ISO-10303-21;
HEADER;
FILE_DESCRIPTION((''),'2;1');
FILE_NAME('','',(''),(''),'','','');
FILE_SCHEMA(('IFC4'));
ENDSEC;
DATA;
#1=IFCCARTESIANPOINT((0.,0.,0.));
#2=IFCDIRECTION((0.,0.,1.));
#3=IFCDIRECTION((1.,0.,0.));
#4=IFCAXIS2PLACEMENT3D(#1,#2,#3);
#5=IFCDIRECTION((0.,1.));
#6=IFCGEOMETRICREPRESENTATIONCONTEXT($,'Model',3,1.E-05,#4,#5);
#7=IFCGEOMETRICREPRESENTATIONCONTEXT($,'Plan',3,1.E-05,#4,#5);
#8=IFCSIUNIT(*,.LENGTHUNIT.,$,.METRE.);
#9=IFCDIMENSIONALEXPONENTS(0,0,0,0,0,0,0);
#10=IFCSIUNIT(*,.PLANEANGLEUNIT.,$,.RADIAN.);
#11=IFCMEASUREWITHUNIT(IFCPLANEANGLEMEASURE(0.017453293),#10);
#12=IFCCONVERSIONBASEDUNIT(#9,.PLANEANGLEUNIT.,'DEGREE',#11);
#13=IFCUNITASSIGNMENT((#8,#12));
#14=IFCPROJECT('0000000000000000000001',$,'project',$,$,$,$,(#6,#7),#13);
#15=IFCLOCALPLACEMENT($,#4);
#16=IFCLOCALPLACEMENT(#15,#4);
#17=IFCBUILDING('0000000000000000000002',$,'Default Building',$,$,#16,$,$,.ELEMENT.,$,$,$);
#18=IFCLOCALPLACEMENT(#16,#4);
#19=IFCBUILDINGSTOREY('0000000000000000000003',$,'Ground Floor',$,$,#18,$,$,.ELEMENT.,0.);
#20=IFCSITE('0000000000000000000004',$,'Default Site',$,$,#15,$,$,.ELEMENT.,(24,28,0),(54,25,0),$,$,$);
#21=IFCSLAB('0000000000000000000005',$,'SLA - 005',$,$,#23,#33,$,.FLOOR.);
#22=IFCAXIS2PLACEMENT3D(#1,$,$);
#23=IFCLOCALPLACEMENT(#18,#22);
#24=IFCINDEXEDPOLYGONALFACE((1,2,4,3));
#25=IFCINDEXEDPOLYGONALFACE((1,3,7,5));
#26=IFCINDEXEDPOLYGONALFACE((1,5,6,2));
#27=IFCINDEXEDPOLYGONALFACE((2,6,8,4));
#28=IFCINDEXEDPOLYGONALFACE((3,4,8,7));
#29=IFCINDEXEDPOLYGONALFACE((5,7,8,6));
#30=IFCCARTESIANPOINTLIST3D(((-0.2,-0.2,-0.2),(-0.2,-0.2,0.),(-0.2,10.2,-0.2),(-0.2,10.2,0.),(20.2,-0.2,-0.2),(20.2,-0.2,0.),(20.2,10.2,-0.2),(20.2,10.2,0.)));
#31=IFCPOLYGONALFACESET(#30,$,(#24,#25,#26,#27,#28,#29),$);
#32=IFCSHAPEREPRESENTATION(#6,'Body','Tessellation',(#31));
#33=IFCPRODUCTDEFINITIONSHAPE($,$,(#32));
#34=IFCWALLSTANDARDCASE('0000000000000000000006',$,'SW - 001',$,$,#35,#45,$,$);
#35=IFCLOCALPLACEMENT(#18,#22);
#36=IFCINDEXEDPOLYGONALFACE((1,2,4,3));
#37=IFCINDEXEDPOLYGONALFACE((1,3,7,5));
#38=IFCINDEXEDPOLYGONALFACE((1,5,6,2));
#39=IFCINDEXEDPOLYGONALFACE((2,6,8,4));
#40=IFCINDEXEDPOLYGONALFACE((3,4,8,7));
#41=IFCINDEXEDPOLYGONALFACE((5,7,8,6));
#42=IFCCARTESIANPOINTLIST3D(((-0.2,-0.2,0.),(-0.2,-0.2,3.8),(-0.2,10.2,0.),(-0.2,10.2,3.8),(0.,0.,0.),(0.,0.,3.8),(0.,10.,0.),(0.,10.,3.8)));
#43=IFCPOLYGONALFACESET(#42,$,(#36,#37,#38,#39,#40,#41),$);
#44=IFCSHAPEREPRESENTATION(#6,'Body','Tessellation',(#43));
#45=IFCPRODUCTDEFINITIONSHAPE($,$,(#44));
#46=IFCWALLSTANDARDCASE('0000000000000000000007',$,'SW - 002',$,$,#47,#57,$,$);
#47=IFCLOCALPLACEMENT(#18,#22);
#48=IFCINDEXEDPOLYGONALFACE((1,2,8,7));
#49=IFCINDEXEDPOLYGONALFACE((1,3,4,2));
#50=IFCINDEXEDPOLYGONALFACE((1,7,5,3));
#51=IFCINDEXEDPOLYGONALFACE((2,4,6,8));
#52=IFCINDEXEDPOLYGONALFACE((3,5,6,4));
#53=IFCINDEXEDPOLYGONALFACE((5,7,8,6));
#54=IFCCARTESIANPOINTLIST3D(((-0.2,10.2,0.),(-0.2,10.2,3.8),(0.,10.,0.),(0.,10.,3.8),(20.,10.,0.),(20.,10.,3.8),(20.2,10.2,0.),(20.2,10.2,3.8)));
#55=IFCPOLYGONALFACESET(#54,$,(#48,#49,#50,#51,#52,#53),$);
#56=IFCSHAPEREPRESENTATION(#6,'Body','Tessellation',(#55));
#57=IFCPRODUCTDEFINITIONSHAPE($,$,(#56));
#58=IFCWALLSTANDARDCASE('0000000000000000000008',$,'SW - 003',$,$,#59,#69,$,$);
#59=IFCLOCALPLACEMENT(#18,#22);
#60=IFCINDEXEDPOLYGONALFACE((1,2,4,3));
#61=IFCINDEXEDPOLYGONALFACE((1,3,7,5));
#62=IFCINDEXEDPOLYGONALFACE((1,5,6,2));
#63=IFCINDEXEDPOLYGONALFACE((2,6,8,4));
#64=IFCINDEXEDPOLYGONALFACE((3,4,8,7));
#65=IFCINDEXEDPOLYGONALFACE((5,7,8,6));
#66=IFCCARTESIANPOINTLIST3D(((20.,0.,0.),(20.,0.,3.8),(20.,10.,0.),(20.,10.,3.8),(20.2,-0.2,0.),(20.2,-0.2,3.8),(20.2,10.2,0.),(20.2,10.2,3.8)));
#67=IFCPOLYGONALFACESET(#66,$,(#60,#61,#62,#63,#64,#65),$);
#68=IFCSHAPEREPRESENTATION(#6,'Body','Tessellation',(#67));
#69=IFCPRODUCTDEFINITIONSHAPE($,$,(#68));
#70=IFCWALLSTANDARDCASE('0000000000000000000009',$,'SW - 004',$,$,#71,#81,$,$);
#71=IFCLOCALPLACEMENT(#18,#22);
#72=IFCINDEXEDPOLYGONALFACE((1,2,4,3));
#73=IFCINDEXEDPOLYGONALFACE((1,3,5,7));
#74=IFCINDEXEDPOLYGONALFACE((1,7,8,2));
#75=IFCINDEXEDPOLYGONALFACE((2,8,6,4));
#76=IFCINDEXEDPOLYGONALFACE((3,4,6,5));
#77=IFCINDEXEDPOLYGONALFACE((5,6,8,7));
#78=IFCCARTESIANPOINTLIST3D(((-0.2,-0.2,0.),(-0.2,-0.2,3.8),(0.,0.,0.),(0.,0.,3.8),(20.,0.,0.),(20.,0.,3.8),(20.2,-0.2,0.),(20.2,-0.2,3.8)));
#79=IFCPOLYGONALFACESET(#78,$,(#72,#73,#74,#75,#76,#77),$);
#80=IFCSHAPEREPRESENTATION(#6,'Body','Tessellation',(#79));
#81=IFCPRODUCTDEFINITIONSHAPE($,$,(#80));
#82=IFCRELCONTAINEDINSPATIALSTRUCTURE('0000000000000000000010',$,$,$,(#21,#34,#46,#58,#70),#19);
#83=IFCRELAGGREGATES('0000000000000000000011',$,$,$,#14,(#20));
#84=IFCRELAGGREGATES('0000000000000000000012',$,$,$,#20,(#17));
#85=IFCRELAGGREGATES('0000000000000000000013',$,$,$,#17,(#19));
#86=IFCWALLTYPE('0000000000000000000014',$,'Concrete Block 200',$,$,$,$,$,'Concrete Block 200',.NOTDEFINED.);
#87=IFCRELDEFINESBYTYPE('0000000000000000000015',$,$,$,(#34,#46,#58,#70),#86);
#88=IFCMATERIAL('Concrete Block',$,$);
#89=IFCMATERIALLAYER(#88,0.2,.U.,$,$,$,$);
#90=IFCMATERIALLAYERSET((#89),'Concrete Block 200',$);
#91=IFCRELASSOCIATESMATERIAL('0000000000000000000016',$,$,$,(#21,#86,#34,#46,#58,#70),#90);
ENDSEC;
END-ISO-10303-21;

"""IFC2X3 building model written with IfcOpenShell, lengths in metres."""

from ifc_helpers import new_model, entity, si_unit, converted_unit, direction, frame, origin_with_axes, place, context, project, spatial, polyline, outline, extrude, material, layer, layer_set, layer_usage, type_object, element, save


model = new_model("IFC2X3")

# Units and contexts
model_context = context("Model", 3, precision=1e-05, world=origin_with_axes(), true_north=direction((0.0, 1.0)))
plan_context = context("Plan", 3, precision=1e-05, world=origin_with_axes(), true_north=direction((0.0, 1.0)))
ifc_project = project(units=[si_unit("LENGTHUNIT", "METRE"), converted_unit("PLANEANGLEUNIT", "DEGREE", entity("IfcPlaneAngleMeasure", 0.017453293), si_unit("PLANEANGLEUNIT", "RADIAN"), dimensions=[0, 0, 0, 0, 0, 0, 0])], contexts=[model_context, plan_context])

# Site, building, storey
site_placement = place(None, origin_with_axes())
site = spatial("IfcSite", under=ifc_project, at=site_placement, Name="Default Site", CompositionType="ELEMENT", RefLatitude=(24, 28, 0), RefLongitude=(54, 25, 0))
building_placement = place(site_placement, origin_with_axes())
building = spatial("IfcBuilding", under=site, at=building_placement, Name="Default Building", CompositionType="ELEMENT")
storey_placement = place(building_placement, origin_with_axes())
storey = spatial("IfcBuildingStorey", under=building, at=storey_placement, Name="Ground Floor", CompositionType="ELEMENT", Elevation=0.0)

# Slab
ifc_material = material(Name="Concrete Block")
ifc_layer = layer(ifc_material, 0.2, ventilated="UNKNOWN")
ifc_layer_set = layer_set([ifc_layer], Name="Concrete Block 200")
ifc_layer_usage_1 = layer_usage(ifc_layer_set, "AXIS3", "NEGATIVE", 0.2)
slab_placement = place(storey_placement, frame((-0.2, 10.2, -0.2), z_axis=(0.0, 0.0, 1.0), x_axis=(1.0, 0.0, 0.0)))
element("IfcSlab", 1, at=slab_placement, inside=storey, material=ifc_layer_usage_1, Name="SLA - 005", PredefinedType="FLOOR", context=model_context, shape_type="SweptSolid", body=[
    extrude(outline(polyline([(0.0, 0.0), (20.4, 0.0), (20.4, -10.4), (0.0, -10.4), (0.0, 0.0)])), origin_with_axes(), (0.0, 0.0, 1.0), 0.2),
])

# Walls
ifc_layer_usage_2 = layer_usage(ifc_layer_set, "AXIS2", "POSITIVE", 0.0)
wall_type = type_object("IfcWallType", Name="Concrete Block 200", ElementType="Concrete Block 200", PredefinedType="NOTDEFINED", material=ifc_layer_set)
wall_1_placement = place(storey_placement, frame((0.0, 0.0, 0.0), z_axis=(0.0, 0.0, 1.0), x_axis=(0.0, 1.0, 0.0)))
element("IfcWallStandardCase", 2, at=wall_1_placement, inside=storey, type_object=wall_type, material=ifc_layer_usage_2, Name="SW - 001", context=model_context, shape_type="SweptSolid", body=[
    extrude(outline(polyline([(0.0, 0.0), (10.0, 0.0), (10.2, 0.2), (-0.2, 0.2), (0.0, 0.0)])), origin_with_axes(), (0.0, 0.0, 1.0), 3.8),
])
ifc_layer_usage_3 = layer_usage(ifc_layer_set, "AXIS2", "POSITIVE", 0.0)
wall_2_placement = place(storey_placement, frame((0.0, 10.0, 0.0), z_axis=(0.0, 0.0, 1.0), x_axis=(1.0, 0.0, 0.0)))
element("IfcWallStandardCase", 3, at=wall_2_placement, inside=storey, type_object=wall_type, material=ifc_layer_usage_3, Name="SW - 002", context=model_context, shape_type="SweptSolid", body=[
    extrude(outline(polyline([(0.0, 0.0), (20.0, 0.0), (20.2, 0.2), (-0.2, 0.2), (0.0, 0.0)])), origin_with_axes(), (0.0, 0.0, 1.0), 3.8),
])
ifc_layer_usage_4 = layer_usage(ifc_layer_set, "AXIS2", "POSITIVE", 0.0)
wall_3_placement = place(storey_placement, frame((20.0, 10.0, 0.0), z_axis=(0.0, 0.0, 1.0), x_axis=(0.0, -1.0, 0.0)))
element("IfcWallStandardCase", 4, at=wall_3_placement, inside=storey, type_object=wall_type, material=ifc_layer_usage_4, Name="SW - 003", context=model_context, shape_type="SweptSolid", body=[
    extrude(outline(polyline([(0.0, 0.0), (10.0, 0.0), (10.2, 0.2), (-0.2, 0.2), (0.0, 0.0)])), origin_with_axes(), (0.0, 0.0, 1.0), 3.8),
])
ifc_layer_usage_5 = layer_usage(ifc_layer_set, "AXIS2", "POSITIVE", 0.0)
wall_4_placement = place(storey_placement, frame((20.0, 0.0, 0.0), z_axis=(0.0, 0.0, 1.0), x_axis=(-1.0, 0.0, 0.0)))
element("IfcWallStandardCase", 5, at=wall_4_placement, inside=storey, type_object=wall_type, material=ifc_layer_usage_5, Name="SW - 004", context=model_context, shape_type="SweptSolid", body=[
    extrude(outline(polyline([(0.0, 0.0), (20.0, 0.0), (20.2, 0.2), (-0.2, 0.2), (0.0, 0.0)])), origin_with_axes(), (0.0, 0.0, 1.0), 3.8),
])

save(model, "model.ifc")
